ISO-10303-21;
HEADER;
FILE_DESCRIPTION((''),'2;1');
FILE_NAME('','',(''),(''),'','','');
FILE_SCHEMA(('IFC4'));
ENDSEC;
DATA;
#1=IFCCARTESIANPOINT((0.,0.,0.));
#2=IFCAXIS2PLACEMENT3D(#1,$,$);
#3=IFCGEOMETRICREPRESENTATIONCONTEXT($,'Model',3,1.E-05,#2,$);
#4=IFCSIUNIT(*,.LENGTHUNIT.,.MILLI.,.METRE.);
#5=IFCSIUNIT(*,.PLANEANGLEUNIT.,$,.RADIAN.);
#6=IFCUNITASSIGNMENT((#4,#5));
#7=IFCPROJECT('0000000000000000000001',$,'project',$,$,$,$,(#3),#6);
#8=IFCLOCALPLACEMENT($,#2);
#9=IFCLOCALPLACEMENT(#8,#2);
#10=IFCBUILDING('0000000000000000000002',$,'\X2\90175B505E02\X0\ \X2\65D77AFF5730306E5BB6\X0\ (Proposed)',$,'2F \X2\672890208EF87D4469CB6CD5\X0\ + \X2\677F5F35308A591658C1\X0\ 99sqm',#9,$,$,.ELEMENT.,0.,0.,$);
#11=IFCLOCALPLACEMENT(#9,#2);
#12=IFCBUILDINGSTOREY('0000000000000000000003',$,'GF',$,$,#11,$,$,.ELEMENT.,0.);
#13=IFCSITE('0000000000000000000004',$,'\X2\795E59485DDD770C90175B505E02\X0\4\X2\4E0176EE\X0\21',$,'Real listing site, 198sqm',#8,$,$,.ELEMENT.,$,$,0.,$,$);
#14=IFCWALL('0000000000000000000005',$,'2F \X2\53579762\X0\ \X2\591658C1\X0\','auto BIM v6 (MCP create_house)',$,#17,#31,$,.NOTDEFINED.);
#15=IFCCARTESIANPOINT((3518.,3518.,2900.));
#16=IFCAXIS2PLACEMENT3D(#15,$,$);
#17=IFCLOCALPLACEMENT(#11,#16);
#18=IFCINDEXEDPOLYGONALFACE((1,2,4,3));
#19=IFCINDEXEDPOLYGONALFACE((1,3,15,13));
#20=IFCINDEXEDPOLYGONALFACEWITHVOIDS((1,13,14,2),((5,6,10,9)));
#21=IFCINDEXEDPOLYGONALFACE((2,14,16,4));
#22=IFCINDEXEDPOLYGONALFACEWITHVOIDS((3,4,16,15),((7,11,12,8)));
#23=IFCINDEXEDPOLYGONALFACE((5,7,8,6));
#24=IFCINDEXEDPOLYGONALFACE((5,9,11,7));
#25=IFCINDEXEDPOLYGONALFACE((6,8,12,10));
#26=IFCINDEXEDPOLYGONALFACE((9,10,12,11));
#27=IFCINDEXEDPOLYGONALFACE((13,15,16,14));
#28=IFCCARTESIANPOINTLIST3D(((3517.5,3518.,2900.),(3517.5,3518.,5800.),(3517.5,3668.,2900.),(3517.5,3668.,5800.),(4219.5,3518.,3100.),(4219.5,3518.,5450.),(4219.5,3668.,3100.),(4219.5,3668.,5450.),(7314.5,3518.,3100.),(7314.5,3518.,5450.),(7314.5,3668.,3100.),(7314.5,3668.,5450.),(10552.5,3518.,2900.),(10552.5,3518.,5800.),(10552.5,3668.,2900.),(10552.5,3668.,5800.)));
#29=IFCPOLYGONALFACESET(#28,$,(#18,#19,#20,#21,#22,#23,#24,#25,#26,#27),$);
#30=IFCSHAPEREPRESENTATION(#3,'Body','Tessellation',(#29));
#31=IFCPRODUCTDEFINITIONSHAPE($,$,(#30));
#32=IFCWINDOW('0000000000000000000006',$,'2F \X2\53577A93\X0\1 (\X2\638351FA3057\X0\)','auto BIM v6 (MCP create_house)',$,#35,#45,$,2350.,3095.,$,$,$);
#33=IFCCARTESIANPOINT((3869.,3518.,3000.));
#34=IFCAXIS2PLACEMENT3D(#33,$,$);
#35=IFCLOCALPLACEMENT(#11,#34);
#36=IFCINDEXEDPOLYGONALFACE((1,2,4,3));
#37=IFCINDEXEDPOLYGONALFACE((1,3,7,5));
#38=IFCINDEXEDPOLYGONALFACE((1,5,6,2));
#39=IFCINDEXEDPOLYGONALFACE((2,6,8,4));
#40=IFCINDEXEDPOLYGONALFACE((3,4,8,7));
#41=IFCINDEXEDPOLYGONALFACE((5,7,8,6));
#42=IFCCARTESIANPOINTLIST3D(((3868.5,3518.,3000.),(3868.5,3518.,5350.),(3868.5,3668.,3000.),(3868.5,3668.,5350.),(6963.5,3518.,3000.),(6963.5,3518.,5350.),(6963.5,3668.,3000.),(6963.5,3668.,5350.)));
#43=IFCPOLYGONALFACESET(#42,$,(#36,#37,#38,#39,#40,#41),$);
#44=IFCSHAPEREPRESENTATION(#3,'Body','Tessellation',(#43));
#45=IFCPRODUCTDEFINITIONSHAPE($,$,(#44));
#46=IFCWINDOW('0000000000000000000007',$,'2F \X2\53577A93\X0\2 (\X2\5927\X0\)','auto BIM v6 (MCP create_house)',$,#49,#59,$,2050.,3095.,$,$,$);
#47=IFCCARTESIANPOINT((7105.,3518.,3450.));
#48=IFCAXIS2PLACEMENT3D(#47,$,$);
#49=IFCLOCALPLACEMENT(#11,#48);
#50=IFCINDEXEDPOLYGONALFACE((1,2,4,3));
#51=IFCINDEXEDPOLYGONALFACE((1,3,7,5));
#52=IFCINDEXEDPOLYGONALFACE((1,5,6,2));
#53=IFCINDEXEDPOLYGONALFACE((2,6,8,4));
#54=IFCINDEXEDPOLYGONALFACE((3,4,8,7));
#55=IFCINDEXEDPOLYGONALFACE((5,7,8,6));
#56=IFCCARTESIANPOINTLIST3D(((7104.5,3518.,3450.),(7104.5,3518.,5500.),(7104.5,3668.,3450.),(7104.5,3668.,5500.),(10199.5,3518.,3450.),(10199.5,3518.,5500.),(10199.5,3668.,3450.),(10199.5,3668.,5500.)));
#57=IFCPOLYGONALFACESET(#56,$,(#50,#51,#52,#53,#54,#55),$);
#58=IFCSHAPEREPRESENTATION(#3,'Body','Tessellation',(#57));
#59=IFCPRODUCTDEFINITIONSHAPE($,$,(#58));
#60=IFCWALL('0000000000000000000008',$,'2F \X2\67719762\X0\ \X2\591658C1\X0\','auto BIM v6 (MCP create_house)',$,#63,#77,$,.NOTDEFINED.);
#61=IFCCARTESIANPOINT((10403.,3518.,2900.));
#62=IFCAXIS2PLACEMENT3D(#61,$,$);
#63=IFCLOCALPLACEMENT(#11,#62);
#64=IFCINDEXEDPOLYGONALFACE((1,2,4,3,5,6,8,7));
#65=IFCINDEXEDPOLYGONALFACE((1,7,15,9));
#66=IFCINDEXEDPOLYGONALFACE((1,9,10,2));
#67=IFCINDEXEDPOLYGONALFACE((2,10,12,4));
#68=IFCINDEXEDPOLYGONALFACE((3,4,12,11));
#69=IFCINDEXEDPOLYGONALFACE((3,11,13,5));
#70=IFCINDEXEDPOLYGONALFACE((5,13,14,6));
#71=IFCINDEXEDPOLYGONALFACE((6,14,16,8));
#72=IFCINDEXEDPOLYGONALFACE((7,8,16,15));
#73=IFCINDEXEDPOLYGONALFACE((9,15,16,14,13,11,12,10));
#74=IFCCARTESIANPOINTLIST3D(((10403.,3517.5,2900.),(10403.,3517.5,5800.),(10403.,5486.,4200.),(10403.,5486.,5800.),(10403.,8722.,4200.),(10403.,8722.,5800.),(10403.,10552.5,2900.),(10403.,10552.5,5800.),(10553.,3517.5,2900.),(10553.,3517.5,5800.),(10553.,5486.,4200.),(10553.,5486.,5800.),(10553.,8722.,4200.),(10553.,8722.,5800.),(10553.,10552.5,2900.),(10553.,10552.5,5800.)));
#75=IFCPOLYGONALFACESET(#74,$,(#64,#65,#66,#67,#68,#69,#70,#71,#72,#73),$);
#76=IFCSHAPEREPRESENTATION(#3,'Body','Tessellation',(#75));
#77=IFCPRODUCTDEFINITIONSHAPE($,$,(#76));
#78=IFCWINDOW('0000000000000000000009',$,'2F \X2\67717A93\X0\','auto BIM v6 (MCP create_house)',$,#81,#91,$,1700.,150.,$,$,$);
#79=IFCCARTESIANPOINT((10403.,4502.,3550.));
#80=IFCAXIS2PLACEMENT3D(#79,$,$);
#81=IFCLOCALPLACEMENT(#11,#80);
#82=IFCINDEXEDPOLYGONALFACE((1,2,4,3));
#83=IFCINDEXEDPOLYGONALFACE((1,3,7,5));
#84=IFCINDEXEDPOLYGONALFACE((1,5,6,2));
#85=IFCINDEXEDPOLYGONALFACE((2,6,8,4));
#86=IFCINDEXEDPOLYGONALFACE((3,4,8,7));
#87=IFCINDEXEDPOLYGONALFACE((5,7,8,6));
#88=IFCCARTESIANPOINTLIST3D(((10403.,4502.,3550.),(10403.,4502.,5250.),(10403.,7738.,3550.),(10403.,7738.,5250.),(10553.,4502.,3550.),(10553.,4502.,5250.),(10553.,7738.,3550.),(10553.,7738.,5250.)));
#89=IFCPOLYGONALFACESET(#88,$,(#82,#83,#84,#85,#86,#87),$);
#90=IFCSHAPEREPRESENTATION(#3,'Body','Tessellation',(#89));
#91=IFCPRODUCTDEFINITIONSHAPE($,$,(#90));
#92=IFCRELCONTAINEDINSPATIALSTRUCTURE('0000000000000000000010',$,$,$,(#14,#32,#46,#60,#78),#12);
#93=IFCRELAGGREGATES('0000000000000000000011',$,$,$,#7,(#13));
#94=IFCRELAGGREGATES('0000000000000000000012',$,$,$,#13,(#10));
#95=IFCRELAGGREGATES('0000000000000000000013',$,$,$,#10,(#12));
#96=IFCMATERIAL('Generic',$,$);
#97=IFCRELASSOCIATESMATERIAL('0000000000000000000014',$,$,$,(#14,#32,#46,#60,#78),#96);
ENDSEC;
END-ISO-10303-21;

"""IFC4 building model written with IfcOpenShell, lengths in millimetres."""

from ifc_helpers import new_model, si_unit, frame, frame_2d, origin, place, context, project, spatial, rectangle, extrude, material, element, fill, save


model = new_model("IFC4")

# Units and contexts
model_context = context("Model", 3, precision=1e-05, world=origin())
ifc_project = project(units=[si_unit("LENGTHUNIT", "METRE", prefix="MILLI"), si_unit("PLANEANGLEUNIT", "RADIAN")], contexts=[model_context])

# Site, building, storey
site_placement = place(None, origin())
site = spatial("IfcSite", under=ifc_project, at=site_placement, Name="神奈川県逗子市4丁目21", ObjectType="Real listing site, 198sqm", CompositionType="ELEMENT", RefElevation=0.0)
building_placement = place(site_placement, origin())
building = spatial("IfcBuilding", under=site, at=building_placement, Name="逗子市 旗竿地の家 (Proposed)", ObjectType="2F 木造軸組構法 + 板張り外壁 99sqm", CompositionType="ELEMENT", ElevationOfRefHeight=0.0, ElevationOfTerrain=0.0)
storey_placement = place(building_placement, origin())
storey = spatial("IfcBuildingStorey", under=building, at=storey_placement, Name="GF", CompositionType="ELEMENT", Elevation=0.0)

# Shared definitions
ifc_material = material(Name="Generic")

# Wall, openings, windows
wall_1_placement = place(storey_placement, frame((3518.0, 3518.0, 2900.0)))
wall_1 = element("IfcWall", 1, at=wall_1_placement, inside=storey, material=ifc_material, Name="2F 南面 外壁", Description="auto BIM v6 (MCP create_house)", PredefinedType="NOTDEFINED", context=model_context, shape_type="SweptSolid", body=[
    extrude(rectangle(XDim=7035.0, YDim=150.0, at=frame_2d((3517.0, 75.0))), frame((3518.0, 3518.0, 2900.0)), (0.0, 0.0, 1.0), 2900.0),
])
opening_1_placement = place(storey_placement, frame((3869.0, 3518.0, 3000.0)))
opening_1 = element("IfcOpeningElement", 2, at=opening_1_placement, cuts=wall_1, PredefinedType="NOTDEFINED", context=model_context, shape_type="SweptSolid", body=[
    extrude(rectangle(XDim=3095.0, YDim=150.0, at=frame_2d((1547.0, 75.0))), frame((3869.0, 3518.0, 3000.0)), (0.0, 0.0, 1.0), 2350.0),
])
opening_2_placement = place(storey_placement, frame((7105.0, 3518.0, 3450.0)))
opening_2 = element("IfcOpeningElement", 3, at=opening_2_placement, cuts=wall_1, PredefinedType="NOTDEFINED", context=model_context, shape_type="SweptSolid", body=[
    extrude(rectangle(XDim=3095.0, YDim=150.0, at=frame_2d((1547.0, 75.0))), frame((7105.0, 3518.0, 3450.0)), (0.0, 0.0, 1.0), 2050.0),
])
window_1_placement = place(storey_placement, frame((3869.0, 3518.0, 3000.0)))
window_1 = element("IfcWindow", 4, at=window_1_placement, inside=storey, material=ifc_material, Name="2F 南窓1 (掃出し)", Description="auto BIM v6 (MCP create_house)", OverallHeight=2350.0, OverallWidth=3095.0, context=model_context, shape_type="SweptSolid", body=[
    extrude(rectangle(XDim=3095.0, YDim=150.0, at=frame_2d((1547.0, 75.0))), frame((3869.0, 3518.0, 3000.0)), (0.0, 0.0, 1.0), 2350.0),
])
fill(opening_1, window_1)
window_2_placement = place(storey_placement, frame((7105.0, 3518.0, 3450.0)))
window_2 = element("IfcWindow", 5, at=window_2_placement, inside=storey, material=ifc_material, Name="2F 南窓2 (大)", Description="auto BIM v6 (MCP create_house)", OverallHeight=2050.0, OverallWidth=3095.0, context=model_context, shape_type="SweptSolid", body=[
    extrude(rectangle(XDim=3095.0, YDim=150.0, at=frame_2d((1547.0, 75.0))), frame((7105.0, 3518.0, 3450.0)), (0.0, 0.0, 1.0), 2050.0),
])
fill(opening_2, window_2)

# Wall, opening, window
wall_2_placement = place(storey_placement, frame((10403.0, 3518.0, 2900.0)))
wall_2 = element("IfcWall", 6, at=wall_2_placement, inside=storey, material=ifc_material, Name="2F 東面 外壁", Description="auto BIM v6 (MCP create_house)", PredefinedType="NOTDEFINED", context=model_context, shape_type="SweptSolid", body=[
    extrude(rectangle(XDim=150.0, YDim=7035.0, at=frame_2d((75.0, 3517.0))), frame((10403.0, 3518.0, 2900.0)), (0.0, 0.0, 1.0), 2900.0),
])
opening_3_placement = place(storey_placement, frame((10403.0, 4502.0, 3550.0)))
opening_3 = element("IfcOpeningElement", 7, at=opening_3_placement, cuts=wall_2, PredefinedType="NOTDEFINED", context=model_context, shape_type="SweptSolid", body=[
    extrude(rectangle(XDim=150.0, YDim=3236.0, at=frame_2d((75.0, 1618.0))), frame((10403.0, 4502.0, 3550.0)), (0.0, 0.0, 1.0), 1700.0),
])
window_3_placement = place(storey_placement, frame((10403.0, 4502.0, 3550.0)))
window_3 = element("IfcWindow", 8, at=window_3_placement, inside=storey, material=ifc_material, Name="2F 東窓", Description="auto BIM v6 (MCP create_house)", OverallHeight=1700.0, OverallWidth=150.0, context=model_context, shape_type="SweptSolid", body=[
    extrude(rectangle(XDim=150.0, YDim=3236.0, at=frame_2d((75.0, 1618.0))), frame((10403.0, 4502.0, 3550.0)), (0.0, 0.0, 1.0), 1700.0),
])
fill(opening_3, window_3)

save(model, "model.ifc")
